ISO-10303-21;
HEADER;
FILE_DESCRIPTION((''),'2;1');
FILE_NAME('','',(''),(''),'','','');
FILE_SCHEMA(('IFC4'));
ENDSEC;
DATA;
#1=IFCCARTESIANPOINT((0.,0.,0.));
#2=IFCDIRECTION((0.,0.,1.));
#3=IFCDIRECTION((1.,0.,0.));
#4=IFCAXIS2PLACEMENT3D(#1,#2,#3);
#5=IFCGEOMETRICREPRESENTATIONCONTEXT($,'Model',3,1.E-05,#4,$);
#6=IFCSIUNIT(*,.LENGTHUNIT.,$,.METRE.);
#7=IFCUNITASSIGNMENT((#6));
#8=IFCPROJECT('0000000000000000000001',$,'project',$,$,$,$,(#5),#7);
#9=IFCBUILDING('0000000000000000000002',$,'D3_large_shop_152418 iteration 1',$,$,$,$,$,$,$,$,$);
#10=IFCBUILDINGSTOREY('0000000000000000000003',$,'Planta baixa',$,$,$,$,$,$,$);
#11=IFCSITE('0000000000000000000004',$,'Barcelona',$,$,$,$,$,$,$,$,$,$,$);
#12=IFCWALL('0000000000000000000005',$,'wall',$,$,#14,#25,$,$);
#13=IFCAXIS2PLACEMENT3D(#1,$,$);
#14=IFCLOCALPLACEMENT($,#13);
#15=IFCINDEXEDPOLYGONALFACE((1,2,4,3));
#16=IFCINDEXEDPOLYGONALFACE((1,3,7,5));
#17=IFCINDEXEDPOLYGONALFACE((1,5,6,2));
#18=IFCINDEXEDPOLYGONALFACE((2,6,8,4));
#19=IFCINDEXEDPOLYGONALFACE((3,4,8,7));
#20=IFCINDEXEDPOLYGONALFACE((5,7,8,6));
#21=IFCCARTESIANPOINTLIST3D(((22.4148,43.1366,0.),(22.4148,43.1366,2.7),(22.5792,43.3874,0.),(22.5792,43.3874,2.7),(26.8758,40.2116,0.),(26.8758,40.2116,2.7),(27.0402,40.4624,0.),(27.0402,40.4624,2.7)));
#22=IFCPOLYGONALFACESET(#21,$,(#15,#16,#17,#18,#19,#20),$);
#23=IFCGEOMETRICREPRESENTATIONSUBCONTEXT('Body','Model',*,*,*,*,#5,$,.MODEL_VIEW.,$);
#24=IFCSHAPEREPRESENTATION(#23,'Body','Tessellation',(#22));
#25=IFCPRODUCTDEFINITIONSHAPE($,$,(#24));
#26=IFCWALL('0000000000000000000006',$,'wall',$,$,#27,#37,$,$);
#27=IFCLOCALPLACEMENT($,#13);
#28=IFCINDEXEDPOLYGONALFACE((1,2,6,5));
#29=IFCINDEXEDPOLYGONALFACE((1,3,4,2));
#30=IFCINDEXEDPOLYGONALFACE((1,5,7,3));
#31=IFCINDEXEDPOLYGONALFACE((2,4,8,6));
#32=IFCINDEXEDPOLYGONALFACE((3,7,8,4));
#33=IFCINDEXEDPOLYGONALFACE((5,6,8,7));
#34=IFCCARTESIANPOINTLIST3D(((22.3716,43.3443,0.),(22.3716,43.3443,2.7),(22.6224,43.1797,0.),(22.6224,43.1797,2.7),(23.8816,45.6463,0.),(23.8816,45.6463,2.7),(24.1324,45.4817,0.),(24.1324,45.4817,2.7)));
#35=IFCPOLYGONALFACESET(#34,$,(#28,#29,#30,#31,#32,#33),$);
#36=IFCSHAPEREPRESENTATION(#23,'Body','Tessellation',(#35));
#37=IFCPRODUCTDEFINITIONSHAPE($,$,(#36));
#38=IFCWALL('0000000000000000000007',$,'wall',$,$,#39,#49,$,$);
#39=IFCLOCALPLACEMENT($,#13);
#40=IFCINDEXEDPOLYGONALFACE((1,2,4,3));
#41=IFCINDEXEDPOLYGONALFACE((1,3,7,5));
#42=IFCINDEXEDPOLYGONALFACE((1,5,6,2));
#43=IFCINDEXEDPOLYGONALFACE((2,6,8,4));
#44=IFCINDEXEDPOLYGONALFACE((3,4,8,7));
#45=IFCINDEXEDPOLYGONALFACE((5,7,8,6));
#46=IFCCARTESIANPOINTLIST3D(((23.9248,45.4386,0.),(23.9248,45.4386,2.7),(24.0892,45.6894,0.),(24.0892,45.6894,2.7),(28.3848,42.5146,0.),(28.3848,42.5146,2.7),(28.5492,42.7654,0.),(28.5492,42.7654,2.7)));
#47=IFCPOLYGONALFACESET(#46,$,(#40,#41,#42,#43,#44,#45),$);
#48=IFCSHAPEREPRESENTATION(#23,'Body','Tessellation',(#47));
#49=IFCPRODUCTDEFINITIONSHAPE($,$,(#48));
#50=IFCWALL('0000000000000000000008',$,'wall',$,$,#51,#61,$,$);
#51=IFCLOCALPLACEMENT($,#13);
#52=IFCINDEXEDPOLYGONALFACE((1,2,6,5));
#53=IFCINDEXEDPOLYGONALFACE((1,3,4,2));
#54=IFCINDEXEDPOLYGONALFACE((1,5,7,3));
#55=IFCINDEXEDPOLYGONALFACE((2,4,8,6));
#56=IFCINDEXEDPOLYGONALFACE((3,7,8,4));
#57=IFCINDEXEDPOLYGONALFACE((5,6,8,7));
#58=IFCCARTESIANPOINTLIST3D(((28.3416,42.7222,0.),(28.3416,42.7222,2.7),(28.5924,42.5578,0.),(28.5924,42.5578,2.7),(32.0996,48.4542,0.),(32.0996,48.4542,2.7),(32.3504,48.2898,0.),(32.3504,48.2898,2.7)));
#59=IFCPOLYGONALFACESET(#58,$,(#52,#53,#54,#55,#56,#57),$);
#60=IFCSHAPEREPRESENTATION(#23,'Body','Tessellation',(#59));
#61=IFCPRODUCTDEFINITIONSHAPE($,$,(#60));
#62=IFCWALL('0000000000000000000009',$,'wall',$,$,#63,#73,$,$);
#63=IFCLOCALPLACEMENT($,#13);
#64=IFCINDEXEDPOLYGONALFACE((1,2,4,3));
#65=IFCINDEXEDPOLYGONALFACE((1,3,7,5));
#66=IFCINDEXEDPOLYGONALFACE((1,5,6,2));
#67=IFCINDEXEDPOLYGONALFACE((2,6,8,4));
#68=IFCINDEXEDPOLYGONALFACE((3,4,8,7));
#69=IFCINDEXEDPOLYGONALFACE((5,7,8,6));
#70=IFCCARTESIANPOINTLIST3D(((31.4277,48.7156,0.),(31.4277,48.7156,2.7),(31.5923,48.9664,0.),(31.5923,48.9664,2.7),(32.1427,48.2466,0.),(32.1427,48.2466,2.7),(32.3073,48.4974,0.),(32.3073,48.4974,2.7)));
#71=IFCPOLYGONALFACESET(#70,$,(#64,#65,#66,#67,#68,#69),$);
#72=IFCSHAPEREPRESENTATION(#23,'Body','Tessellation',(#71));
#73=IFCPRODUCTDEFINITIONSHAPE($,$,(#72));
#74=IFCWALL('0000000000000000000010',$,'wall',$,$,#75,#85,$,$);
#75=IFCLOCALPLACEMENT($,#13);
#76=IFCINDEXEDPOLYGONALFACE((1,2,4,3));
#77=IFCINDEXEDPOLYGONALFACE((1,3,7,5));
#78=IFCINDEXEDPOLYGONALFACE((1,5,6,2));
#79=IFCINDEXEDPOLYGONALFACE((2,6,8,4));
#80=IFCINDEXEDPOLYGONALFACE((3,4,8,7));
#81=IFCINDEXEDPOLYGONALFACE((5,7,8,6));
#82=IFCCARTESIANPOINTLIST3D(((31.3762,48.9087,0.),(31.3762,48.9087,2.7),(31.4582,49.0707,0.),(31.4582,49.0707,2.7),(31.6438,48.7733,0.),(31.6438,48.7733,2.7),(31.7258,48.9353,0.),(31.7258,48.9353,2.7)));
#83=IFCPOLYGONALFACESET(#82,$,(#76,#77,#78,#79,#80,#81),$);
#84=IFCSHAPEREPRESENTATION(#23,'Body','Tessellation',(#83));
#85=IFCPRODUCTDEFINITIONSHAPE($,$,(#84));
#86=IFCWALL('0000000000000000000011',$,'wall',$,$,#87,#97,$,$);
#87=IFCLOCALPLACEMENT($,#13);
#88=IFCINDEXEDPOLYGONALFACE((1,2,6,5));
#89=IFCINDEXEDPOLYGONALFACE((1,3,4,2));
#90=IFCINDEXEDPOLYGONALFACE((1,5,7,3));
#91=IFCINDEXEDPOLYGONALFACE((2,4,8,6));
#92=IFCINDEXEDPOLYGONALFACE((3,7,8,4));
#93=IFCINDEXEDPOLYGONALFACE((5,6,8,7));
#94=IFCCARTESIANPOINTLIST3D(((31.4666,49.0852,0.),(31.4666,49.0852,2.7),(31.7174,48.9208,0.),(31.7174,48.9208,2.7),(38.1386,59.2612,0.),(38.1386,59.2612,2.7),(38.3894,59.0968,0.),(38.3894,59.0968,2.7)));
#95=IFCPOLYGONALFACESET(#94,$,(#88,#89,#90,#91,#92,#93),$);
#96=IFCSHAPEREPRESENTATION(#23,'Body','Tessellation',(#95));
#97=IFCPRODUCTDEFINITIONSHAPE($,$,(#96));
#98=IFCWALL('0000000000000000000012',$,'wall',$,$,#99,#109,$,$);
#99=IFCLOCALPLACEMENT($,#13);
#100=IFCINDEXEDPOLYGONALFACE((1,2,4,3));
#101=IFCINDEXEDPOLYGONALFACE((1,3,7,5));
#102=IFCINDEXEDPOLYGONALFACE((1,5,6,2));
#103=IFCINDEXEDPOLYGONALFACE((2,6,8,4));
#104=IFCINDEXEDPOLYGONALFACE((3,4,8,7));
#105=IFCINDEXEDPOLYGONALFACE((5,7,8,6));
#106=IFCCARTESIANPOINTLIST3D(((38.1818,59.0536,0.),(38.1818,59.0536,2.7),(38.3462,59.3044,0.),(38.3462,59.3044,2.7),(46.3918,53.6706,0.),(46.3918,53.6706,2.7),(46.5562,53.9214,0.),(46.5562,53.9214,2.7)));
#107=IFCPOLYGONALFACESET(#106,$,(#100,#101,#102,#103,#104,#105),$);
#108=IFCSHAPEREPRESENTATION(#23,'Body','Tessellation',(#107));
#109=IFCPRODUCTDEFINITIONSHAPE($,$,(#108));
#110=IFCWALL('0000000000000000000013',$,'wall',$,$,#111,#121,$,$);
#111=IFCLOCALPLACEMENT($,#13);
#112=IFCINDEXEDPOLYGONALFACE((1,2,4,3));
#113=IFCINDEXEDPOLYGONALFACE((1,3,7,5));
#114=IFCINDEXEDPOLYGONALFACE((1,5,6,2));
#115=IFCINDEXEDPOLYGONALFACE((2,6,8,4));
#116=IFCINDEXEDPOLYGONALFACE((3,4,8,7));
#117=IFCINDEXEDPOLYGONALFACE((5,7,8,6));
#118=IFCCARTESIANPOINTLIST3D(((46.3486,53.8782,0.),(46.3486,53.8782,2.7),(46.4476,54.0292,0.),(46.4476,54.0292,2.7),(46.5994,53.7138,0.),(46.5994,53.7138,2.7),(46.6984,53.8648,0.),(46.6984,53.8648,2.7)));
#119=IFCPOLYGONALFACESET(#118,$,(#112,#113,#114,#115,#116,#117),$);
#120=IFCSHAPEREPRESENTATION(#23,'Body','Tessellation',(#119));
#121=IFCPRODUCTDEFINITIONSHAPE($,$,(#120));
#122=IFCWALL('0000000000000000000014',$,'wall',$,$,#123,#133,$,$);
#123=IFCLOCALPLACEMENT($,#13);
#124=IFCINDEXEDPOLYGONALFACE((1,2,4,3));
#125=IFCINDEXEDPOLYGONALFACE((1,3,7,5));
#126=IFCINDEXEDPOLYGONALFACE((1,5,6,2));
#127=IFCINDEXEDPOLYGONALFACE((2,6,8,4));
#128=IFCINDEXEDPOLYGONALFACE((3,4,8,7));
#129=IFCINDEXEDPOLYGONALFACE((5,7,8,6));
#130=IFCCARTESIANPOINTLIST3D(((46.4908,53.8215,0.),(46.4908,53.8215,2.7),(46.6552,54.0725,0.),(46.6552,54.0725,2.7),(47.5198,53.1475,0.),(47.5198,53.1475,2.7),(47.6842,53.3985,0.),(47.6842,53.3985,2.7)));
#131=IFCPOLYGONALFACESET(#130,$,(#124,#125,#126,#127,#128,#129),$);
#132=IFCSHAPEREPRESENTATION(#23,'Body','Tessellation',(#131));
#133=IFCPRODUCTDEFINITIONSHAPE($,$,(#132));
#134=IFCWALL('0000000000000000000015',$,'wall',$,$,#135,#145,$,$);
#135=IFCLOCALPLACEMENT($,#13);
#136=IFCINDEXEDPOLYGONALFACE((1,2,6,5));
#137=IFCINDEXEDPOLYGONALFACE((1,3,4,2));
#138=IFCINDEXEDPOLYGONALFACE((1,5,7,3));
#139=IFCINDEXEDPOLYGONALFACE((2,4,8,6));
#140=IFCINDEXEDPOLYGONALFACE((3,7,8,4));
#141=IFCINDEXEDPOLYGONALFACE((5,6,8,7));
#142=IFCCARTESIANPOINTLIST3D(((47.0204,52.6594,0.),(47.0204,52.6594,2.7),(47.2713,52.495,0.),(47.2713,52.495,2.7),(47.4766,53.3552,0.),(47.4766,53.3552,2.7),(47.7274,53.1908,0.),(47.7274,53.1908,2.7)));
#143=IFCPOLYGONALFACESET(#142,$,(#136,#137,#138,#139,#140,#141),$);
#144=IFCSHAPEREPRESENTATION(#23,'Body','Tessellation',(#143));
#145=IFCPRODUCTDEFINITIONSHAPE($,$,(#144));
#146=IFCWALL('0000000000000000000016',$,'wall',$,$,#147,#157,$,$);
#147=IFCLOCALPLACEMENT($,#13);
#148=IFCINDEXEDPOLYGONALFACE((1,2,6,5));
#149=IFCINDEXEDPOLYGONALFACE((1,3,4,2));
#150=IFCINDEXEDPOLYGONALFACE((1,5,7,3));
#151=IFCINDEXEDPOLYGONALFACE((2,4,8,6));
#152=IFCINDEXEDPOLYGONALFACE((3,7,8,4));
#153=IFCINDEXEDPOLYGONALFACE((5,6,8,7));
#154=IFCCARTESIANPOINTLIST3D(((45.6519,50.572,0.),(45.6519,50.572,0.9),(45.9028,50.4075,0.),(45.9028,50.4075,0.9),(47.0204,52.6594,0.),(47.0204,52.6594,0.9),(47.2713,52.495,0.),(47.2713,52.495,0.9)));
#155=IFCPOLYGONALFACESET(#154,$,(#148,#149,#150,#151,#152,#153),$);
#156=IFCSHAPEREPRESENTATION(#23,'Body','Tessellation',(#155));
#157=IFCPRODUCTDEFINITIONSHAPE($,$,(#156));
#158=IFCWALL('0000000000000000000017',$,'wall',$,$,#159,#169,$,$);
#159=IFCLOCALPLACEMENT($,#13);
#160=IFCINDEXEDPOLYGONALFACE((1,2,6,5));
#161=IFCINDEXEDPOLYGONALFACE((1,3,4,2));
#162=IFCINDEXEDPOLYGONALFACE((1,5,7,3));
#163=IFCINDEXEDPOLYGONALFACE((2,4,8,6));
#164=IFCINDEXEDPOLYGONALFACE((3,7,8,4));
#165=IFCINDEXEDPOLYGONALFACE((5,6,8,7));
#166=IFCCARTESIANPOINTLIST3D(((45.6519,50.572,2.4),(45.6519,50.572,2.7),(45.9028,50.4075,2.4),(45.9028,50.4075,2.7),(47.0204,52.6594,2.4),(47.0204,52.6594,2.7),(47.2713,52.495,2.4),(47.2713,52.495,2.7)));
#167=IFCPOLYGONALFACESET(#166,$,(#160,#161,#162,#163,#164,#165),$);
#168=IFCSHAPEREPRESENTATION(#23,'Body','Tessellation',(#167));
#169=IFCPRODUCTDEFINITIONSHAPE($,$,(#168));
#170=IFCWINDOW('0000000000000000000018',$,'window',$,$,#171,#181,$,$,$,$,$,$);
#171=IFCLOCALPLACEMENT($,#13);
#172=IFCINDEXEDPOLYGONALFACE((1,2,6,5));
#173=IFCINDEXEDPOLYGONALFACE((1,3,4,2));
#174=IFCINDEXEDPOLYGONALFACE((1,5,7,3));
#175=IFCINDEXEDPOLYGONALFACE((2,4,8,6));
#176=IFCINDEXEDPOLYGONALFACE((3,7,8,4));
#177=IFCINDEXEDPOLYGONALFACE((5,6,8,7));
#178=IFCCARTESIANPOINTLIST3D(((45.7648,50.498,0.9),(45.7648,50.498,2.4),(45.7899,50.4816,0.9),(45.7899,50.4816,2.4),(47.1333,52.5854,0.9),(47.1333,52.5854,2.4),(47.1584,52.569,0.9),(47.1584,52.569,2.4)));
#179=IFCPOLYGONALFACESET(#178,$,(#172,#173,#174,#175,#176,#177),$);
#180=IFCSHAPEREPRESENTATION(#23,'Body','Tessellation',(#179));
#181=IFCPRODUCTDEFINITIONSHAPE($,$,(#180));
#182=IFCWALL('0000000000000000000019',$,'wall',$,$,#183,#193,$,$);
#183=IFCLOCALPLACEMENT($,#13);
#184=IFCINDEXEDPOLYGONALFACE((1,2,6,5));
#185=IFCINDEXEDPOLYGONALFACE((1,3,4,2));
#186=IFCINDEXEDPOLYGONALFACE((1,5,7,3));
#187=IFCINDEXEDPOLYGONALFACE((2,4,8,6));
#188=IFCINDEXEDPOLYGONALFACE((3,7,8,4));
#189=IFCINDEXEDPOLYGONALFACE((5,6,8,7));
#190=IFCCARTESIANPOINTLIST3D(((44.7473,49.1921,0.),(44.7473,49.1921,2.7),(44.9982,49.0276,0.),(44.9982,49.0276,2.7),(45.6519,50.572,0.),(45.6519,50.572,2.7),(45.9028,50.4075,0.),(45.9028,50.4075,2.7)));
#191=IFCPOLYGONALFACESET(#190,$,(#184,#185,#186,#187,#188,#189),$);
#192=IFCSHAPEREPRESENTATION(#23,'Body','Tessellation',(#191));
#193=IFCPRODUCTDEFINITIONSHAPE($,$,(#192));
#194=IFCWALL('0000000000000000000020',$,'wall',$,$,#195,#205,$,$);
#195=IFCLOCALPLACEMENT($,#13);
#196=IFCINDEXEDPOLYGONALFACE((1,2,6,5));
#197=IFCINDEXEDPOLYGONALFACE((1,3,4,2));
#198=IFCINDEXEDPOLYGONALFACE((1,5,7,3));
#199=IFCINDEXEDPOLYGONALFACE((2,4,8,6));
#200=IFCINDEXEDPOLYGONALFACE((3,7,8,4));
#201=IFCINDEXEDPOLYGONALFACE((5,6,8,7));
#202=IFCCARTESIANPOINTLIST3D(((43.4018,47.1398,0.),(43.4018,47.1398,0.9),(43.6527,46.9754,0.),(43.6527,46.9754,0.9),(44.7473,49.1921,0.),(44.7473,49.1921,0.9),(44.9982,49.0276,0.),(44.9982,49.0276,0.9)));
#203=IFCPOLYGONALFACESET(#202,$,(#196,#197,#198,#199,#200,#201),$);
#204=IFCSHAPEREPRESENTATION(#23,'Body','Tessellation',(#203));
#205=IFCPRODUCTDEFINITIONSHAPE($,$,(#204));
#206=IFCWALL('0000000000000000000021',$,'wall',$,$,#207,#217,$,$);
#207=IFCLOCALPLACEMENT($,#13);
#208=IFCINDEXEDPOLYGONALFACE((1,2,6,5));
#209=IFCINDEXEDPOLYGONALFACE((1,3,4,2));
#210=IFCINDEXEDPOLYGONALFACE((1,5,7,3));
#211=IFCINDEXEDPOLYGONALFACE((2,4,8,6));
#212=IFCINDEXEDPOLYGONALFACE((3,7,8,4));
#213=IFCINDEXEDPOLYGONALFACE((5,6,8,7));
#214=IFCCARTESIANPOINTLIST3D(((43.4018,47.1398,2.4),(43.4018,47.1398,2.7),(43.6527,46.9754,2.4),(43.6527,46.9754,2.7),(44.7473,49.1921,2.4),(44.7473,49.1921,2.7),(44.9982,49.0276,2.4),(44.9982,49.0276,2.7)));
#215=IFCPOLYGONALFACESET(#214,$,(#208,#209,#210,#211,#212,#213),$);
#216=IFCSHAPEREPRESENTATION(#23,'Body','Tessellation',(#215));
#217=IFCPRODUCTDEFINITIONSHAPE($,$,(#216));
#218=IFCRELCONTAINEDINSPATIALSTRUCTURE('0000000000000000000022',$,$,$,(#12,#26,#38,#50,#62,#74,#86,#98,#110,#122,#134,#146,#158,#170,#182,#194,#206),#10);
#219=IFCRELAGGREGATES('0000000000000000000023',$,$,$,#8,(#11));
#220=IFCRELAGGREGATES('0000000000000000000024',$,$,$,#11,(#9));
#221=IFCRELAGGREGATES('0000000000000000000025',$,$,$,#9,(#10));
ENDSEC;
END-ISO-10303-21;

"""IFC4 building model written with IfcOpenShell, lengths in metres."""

from ifc_helpers import new_model, si_unit, frame, origin, origin_with_axes, place, context, subcontext, project, spatial, polyline, outline, extrude, element, save


model = new_model("IFC4")

# Units and contexts
model_context = context("Model", 3, precision=1e-05, world=origin_with_axes())
body_context = subcontext(model_context, "Body", "Model", "MODEL_VIEW")
ifc_project = project(units=[si_unit("LENGTHUNIT", "METRE")], contexts=[model_context])

# Site, building, storey
site = spatial("IfcSite", under=ifc_project, Name="Barcelona")
building = spatial("IfcBuilding", under=site, Name="D3_large_shop_152418 iteration 1")
storey = spatial("IfcBuildingStorey", under=building, Name="Planta baixa")

# Walls
wall_1_placement = place(None, origin_with_axes())
element("IfcWall", 1, at=wall_1_placement, inside=storey, Name="wall", context=body_context, shape_type="SweptSolid", body=[
    extrude(outline(polyline([(26.8758, 40.2116), (22.4148, 43.1366), (22.5792, 43.3874), (27.0402, 40.4624), (26.8758, 40.2116)])), origin(), (0.0, 0.0, 1.0), 2.7),
])
wall_2_placement = place(None, origin_with_axes())
element("IfcWall", 2, at=wall_2_placement, inside=storey, Name="wall", context=body_context, shape_type="SweptSolid", body=[
    extrude(outline(polyline([(22.3716, 43.3443), (23.8816, 45.6463), (24.1324, 45.4817), (22.6224, 43.1797), (22.3716, 43.3443)])), origin(), (0.0, 0.0, 1.0), 2.7),
])
wall_3_placement = place(None, origin_with_axes())
element("IfcWall", 3, at=wall_3_placement, inside=storey, Name="wall", context=body_context, shape_type="SweptSolid", body=[
    extrude(outline(polyline([(24.0892, 45.6894), (28.5492, 42.7654), (28.3848, 42.5146), (23.9248, 45.4386), (24.0892, 45.6894)])), origin(), (0.0, 0.0, 1.0), 2.7),
])
wall_4_placement = place(None, origin_with_axes())
element("IfcWall", 4, at=wall_4_placement, inside=storey, Name="wall", context=body_context, shape_type="SweptSolid", body=[
    extrude(outline(polyline([(28.3416, 42.7222), (32.0996, 48.4542), (32.3504, 48.2898), (28.5924, 42.5578), (28.3416, 42.7222)])), origin(), (0.0, 0.0, 1.0), 2.7),
])
wall_5_placement = place(None, origin_with_axes())
element("IfcWall", 5, at=wall_5_placement, inside=storey, Name="wall", context=body_context, shape_type="SweptSolid", body=[
    extrude(outline(polyline([(32.1427, 48.2466), (31.4277, 48.7156), (31.5923, 48.9664), (32.3073, 48.4974), (32.1427, 48.2466)])), origin(), (0.0, 0.0, 1.0), 2.7),
])
wall_6_placement = place(None, origin_with_axes())
element("IfcWall", 6, at=wall_6_placement, inside=storey, Name="wall", context=body_context, shape_type="SweptSolid", body=[
    extrude(outline(polyline([(31.3762, 48.9087), (31.4582, 49.0707), (31.7258, 48.9353), (31.6438, 48.7733), (31.3762, 48.9087)])), origin(), (0.0, 0.0, 1.0), 2.7),
])
wall_7_placement = place(None, origin_with_axes())
element("IfcWall", 7, at=wall_7_placement, inside=storey, Name="wall", context=body_context, shape_type="SweptSolid", body=[
    extrude(outline(polyline([(31.4666, 49.0852), (38.1386, 59.2612), (38.3894, 59.0968), (31.7174, 48.9208), (31.4666, 49.0852)])), origin(), (0.0, 0.0, 1.0), 2.7),
])
wall_8_placement = place(None, origin_with_axes())
element("IfcWall", 8, at=wall_8_placement, inside=storey, Name="wall", context=body_context, shape_type="SweptSolid", body=[
    extrude(outline(polyline([(38.3462, 59.3044), (46.5562, 53.9214), (46.3918, 53.6706), (38.1818, 59.0536), (38.3462, 59.3044)])), origin(), (0.0, 0.0, 1.0), 2.7),
])
wall_9_placement = place(None, origin_with_axes())
element("IfcWall", 9, at=wall_9_placement, inside=storey, Name="wall", context=body_context, shape_type="SweptSolid", body=[
    extrude(outline(polyline([(46.3486, 53.8782), (46.4476, 54.0292), (46.6984, 53.8648), (46.5994, 53.7138), (46.3486, 53.8782)])), origin(), (0.0, 0.0, 1.0), 2.7),
])
wall_10_placement = place(None, origin_with_axes())
element("IfcWall", 10, at=wall_10_placement, inside=storey, Name="wall", context=body_context, shape_type="SweptSolid", body=[
    extrude(outline(polyline([(46.6552, 54.0725), (47.6842, 53.3985), (47.5198, 53.1475), (46.4908, 53.8215), (46.6552, 54.0725)])), origin(), (0.0, 0.0, 1.0), 2.7),
])
wall_11_placement = place(None, origin_with_axes())
element("IfcWall", 11, at=wall_11_placement, inside=storey, Name="wall", context=body_context, shape_type="SweptSolid", body=[
    extrude(outline(polyline([(47.7274, 53.1908), (47.2713, 52.495), (47.0204, 52.6594), (47.4766, 53.3552), (47.7274, 53.1908)])), origin(), (0.0, 0.0, 1.0), 2.7),
])
wall_12_placement = place(None, origin_with_axes())
element("IfcWall", 12, at=wall_12_placement, inside=storey, Name="wall", context=body_context, shape_type="SweptSolid", body=[
    extrude(outline(polyline([(47.2713, 52.495), (45.9028, 50.4075), (45.6519, 50.572), (47.0204, 52.6594), (47.2713, 52.495)])), origin(), (0.0, 0.0, 1.0), 0.9),
])
wall_13_placement = place(None, origin_with_axes())
element("IfcWall", 13, at=wall_13_placement, inside=storey, Name="wall", context=body_context, shape_type="SweptSolid", body=[
    extrude(outline(polyline([(47.2713, 52.495), (45.9028, 50.4075), (45.6519, 50.572), (47.0204, 52.6594), (47.2713, 52.495)])), frame((0.0, 0.0, 2.4)), (0.0, 0.0, 1.0), 0.3),
])

# Window
window_1_placement = place(None, origin_with_axes())
element("IfcWindow", 14, at=window_1_placement, inside=storey, Name="window", context=body_context, shape_type="SweptSolid", body=[
    extrude(outline(polyline([(47.1584, 52.569), (45.7899, 50.4816), (45.7648, 50.498), (47.1333, 52.5854), (47.1584, 52.569)])), frame((0.0, 0.0, 0.9)), (0.0, 0.0, 1.0), 1.5),
])

# Walls
wall_14_placement = place(None, origin_with_axes())
element("IfcWall", 15, at=wall_14_placement, inside=storey, Name="wall", context=body_context, shape_type="SweptSolid", body=[
    extrude(outline(polyline([(45.9028, 50.4075), (44.9982, 49.0276), (44.7473, 49.1921), (45.6519, 50.572), (45.9028, 50.4075)])), origin(), (0.0, 0.0, 1.0), 2.7),
])
wall_15_placement = place(None, origin_with_axes())
element("IfcWall", 16, at=wall_15_placement, inside=storey, Name="wall", context=body_context, shape_type="SweptSolid", body=[
    extrude(outline(polyline([(44.9982, 49.0276), (43.6527, 46.9754), (43.4018, 47.1398), (44.7473, 49.1921), (44.9982, 49.0276)])), origin(), (0.0, 0.0, 1.0), 0.9),
])
wall_16_placement = place(None, origin_with_axes())
element("IfcWall", 17, at=wall_16_placement, inside=storey, Name="wall", context=body_context, shape_type="SweptSolid", body=[
    extrude(outline(polyline([(44.9982, 49.0276), (43.6527, 46.9754), (43.4018, 47.1398), (44.7473, 49.1921), (44.9982, 49.0276)])), frame((0.0, 0.0, 2.4)), (0.0, 0.0, 1.0), 0.3),
])

save(model, "model.ifc")
